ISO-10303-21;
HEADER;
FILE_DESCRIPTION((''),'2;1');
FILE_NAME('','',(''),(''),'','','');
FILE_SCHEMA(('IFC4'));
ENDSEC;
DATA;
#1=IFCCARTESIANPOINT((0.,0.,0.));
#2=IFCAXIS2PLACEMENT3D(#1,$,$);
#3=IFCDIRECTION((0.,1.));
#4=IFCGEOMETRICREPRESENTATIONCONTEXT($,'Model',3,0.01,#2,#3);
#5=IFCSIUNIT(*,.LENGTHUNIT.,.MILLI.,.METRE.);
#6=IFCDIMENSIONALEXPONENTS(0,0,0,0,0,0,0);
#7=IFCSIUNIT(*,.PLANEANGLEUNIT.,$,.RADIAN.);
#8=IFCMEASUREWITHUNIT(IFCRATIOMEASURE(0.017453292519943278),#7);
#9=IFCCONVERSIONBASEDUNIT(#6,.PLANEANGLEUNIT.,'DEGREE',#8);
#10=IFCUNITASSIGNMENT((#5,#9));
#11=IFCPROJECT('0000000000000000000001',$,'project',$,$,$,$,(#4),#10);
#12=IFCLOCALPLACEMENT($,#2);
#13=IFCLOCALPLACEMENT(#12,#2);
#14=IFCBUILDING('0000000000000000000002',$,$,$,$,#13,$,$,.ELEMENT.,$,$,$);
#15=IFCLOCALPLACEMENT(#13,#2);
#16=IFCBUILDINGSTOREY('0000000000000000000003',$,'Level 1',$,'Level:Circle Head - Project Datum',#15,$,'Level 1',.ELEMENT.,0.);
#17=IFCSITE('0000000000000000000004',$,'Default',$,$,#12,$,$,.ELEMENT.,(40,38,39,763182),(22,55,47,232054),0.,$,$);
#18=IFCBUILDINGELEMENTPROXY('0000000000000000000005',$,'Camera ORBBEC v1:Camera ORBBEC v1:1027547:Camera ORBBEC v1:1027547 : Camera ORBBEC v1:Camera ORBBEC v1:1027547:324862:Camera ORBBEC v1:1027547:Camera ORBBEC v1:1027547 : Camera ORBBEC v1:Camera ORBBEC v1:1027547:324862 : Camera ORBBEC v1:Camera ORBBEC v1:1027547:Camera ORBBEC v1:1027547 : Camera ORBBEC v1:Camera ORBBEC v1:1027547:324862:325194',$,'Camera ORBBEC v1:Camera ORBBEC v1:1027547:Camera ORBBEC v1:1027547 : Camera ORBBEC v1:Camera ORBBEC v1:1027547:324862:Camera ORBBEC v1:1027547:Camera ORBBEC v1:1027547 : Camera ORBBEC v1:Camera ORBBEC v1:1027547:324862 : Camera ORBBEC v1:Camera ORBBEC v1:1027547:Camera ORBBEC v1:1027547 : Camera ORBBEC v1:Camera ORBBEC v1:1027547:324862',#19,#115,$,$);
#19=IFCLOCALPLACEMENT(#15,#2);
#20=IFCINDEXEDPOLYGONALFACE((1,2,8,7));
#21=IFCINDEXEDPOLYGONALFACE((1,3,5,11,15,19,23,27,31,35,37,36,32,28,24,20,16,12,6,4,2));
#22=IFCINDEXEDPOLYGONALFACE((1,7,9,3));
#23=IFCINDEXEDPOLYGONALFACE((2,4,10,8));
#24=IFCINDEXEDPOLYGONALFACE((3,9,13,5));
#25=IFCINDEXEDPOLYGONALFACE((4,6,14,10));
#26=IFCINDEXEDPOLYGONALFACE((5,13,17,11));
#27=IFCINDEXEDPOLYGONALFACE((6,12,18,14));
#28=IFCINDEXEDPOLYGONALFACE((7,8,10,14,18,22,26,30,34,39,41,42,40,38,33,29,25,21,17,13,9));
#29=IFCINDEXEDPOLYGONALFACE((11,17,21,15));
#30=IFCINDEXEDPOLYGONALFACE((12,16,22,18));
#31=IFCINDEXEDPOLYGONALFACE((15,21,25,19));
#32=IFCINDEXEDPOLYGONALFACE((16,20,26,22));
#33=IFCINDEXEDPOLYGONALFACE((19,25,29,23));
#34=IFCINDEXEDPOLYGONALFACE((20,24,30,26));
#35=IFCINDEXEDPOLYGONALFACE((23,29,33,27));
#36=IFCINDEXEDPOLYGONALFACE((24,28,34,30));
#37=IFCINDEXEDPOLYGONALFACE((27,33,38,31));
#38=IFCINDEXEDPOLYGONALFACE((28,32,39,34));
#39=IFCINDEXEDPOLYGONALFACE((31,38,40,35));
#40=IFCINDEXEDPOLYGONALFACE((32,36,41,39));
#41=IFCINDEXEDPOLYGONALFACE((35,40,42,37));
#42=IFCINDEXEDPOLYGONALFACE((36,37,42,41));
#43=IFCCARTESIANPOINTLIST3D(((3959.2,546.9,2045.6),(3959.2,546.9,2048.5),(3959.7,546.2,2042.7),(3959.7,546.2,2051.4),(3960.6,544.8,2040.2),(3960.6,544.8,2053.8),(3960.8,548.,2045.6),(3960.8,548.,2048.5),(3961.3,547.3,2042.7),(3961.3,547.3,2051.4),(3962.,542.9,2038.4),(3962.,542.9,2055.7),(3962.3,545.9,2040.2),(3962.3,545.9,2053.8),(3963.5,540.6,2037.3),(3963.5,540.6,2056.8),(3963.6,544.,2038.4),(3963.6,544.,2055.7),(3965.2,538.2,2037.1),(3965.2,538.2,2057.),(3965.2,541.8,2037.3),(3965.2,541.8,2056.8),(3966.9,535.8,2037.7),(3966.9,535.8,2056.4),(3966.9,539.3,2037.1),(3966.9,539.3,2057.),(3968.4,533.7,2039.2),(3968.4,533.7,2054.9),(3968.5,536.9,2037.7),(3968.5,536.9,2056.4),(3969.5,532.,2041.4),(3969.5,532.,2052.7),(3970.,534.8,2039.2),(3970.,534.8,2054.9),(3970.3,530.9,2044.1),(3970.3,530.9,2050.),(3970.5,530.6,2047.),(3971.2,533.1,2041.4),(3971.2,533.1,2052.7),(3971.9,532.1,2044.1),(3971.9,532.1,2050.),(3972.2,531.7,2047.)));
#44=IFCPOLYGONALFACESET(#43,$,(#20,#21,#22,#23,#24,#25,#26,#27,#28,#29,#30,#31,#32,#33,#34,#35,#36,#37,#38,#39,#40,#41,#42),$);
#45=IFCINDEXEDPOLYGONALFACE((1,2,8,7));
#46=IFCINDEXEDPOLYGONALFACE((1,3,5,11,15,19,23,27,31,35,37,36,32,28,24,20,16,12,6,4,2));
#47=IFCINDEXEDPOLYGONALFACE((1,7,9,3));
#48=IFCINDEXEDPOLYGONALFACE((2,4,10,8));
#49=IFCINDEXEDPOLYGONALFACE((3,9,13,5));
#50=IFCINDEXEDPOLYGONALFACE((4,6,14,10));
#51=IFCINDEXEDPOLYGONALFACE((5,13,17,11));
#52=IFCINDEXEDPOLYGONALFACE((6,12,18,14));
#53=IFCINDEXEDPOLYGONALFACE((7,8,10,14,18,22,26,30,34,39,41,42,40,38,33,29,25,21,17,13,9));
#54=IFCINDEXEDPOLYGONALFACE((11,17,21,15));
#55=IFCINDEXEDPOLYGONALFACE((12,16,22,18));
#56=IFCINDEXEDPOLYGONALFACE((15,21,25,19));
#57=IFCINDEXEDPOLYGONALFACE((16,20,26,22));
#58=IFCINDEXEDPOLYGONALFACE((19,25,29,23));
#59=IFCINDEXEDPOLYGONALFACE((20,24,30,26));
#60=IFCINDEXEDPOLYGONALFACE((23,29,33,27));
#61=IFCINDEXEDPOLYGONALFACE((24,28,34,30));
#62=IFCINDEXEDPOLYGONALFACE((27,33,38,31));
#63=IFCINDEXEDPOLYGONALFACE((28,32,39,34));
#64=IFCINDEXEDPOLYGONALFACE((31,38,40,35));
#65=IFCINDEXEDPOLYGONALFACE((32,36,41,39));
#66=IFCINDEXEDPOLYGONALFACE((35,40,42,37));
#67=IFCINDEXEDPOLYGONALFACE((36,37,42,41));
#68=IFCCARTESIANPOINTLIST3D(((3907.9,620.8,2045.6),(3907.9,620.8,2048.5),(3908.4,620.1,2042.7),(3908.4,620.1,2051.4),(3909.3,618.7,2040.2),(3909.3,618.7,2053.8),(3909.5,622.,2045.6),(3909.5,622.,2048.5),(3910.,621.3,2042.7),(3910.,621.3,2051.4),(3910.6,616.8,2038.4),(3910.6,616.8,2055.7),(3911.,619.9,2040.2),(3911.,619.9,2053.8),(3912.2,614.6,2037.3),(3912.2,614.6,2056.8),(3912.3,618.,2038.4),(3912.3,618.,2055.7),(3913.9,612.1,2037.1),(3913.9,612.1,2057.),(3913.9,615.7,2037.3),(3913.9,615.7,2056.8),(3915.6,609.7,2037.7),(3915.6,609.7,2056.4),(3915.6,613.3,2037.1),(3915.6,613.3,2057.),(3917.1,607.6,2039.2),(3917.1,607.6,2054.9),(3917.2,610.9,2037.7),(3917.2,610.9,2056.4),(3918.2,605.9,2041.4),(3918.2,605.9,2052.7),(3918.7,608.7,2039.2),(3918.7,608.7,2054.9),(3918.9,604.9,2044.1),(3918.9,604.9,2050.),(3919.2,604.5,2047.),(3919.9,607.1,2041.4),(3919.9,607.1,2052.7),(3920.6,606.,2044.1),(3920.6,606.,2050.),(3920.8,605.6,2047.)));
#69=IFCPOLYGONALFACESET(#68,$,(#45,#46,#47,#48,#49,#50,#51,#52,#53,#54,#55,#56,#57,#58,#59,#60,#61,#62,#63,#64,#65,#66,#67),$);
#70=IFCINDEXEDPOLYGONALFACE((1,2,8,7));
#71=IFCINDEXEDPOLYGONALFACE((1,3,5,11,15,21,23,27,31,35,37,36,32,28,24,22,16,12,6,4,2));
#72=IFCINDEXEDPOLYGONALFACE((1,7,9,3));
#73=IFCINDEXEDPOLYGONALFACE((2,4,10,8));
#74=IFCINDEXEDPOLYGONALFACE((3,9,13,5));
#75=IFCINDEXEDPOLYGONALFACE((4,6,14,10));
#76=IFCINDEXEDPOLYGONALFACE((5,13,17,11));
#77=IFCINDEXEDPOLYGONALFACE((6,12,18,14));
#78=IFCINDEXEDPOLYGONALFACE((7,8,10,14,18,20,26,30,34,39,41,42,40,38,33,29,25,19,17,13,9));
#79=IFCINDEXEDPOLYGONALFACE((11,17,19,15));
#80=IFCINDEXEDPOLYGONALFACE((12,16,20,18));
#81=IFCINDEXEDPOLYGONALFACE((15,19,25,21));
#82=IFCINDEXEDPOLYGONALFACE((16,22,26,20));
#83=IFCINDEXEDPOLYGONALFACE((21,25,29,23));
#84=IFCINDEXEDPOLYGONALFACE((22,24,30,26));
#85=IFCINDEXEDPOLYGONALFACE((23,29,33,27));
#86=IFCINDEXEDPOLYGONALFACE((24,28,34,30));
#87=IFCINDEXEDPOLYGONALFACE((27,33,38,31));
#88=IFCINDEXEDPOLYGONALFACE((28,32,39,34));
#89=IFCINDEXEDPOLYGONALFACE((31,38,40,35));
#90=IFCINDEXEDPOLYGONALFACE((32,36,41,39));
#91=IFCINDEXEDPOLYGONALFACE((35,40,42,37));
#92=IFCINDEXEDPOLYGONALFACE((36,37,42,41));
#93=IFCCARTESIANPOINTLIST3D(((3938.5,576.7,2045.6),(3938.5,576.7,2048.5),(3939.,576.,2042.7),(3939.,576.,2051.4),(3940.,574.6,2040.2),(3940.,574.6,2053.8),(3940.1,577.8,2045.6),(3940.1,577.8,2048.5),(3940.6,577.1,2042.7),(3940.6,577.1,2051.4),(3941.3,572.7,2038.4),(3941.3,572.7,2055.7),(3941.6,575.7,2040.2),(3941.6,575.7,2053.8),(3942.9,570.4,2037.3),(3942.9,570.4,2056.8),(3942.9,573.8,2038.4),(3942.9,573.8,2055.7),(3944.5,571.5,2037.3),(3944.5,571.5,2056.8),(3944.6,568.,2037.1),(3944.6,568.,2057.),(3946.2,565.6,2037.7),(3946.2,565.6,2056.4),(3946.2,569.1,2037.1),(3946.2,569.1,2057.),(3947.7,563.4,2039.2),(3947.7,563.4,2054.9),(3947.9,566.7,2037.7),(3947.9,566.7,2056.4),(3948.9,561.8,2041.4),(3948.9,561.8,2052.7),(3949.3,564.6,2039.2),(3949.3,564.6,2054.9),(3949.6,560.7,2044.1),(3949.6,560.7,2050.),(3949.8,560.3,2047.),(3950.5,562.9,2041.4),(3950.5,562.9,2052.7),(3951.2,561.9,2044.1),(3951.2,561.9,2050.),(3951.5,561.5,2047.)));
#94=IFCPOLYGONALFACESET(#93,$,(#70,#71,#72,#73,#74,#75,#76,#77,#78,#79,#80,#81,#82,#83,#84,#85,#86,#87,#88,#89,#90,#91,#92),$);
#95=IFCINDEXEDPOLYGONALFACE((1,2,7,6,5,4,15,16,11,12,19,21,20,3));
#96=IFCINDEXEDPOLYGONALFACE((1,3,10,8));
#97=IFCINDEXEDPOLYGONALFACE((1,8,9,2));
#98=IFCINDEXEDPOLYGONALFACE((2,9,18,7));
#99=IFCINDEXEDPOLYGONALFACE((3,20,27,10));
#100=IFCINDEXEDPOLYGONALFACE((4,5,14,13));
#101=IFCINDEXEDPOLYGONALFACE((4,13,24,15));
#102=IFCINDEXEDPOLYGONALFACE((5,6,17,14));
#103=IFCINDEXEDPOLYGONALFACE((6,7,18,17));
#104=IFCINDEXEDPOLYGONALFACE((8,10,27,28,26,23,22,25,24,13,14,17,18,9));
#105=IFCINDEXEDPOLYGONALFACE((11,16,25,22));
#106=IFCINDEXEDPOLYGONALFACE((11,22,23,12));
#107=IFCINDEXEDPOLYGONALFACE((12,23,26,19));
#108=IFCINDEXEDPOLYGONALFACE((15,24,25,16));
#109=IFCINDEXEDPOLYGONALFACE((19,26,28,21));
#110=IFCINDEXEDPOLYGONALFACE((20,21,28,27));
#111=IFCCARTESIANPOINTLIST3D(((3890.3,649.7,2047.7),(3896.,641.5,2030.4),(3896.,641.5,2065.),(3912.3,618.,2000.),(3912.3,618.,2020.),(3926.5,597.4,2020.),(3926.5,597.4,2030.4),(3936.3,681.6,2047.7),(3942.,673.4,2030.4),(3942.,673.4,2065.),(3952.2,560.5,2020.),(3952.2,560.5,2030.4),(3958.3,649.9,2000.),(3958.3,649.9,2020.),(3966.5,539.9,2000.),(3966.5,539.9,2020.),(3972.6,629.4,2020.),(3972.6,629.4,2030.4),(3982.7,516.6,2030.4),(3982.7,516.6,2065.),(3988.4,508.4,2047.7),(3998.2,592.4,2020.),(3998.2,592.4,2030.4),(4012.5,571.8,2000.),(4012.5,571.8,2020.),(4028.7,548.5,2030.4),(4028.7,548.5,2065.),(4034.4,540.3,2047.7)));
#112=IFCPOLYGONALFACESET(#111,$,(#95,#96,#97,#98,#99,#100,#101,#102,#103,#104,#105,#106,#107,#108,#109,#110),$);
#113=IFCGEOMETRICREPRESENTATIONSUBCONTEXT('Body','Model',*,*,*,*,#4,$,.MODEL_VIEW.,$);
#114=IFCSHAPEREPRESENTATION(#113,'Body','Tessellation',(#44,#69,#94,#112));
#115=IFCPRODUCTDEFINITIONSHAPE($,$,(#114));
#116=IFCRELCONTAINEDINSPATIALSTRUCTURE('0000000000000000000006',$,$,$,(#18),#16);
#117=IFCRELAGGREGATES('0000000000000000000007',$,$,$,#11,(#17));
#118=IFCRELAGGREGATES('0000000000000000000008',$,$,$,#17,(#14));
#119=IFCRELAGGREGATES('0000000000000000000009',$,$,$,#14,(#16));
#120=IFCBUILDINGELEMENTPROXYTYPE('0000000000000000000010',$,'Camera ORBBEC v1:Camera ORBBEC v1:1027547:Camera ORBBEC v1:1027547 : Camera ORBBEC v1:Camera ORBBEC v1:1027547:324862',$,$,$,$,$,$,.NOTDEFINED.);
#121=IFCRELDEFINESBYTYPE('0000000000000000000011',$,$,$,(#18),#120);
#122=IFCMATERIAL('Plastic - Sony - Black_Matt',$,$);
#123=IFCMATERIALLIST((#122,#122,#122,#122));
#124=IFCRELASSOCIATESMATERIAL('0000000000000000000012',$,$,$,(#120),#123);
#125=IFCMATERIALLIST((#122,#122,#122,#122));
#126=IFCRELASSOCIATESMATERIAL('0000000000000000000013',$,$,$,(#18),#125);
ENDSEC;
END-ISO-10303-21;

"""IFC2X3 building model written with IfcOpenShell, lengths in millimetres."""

from ifc_helpers import new_model, entity, si_unit, converted_unit, direction, frame, frame_2d, origin, origin_2d_with_axis, place, context, subcontext, project, spatial, polyline, circle, outline, extrude, source, transform, mapped, material, material_list, type_object, type_shapes, element, save


model = new_model("IFC2X3")

# Units and contexts
model_context = context("Model", 3, precision=0.01, world=origin(), true_north=direction((0.0, 1.0)))
body_context = subcontext(model_context, "Body", "Model", "MODEL_VIEW")
ifc_project = project(units=[si_unit("LENGTHUNIT", "METRE", prefix="MILLI"), converted_unit("PLANEANGLEUNIT", "DEGREE", entity("IfcRatioMeasure", 0.017453292519943278), si_unit("PLANEANGLEUNIT", "RADIAN"), dimensions=[0, 0, 0, 0, 0, 0, 0])], contexts=[model_context])

# Site, building, storey
site_placement = place(None, origin())
site = spatial("IfcSite", under=ifc_project, at=site_placement, Name="Default", CompositionType="ELEMENT", RefLatitude=(40, 38, 39, 763182), RefLongitude=(22, 55, 47, 232054), RefElevation=0.0)
building_placement = place(site_placement, origin())
building = spatial("IfcBuilding", under=site, at=building_placement, CompositionType="ELEMENT")
storey_placement = place(building_placement, origin())
storey = spatial("IfcBuildingStorey", under=building, at=storey_placement, Name="Level 1", ObjectType="Level:Circle Head - Project Datum", LongName="Level 1", CompositionType="ELEMENT", Elevation=0.0)

# Building element proxy
ifc_material_1 = material(Name="Plastic - Sony - Black_Matt")
ifc_material_list_1 = material_list([ifc_material_1, ifc_material_1, ifc_material_1, ifc_material_1])
ifc_material_list_2 = material_list([ifc_material_1, ifc_material_1, ifc_material_1, ifc_material_1])
building_element_proxy_type_1 = type_object("IfcBuildingElementProxyType", Name="Camera ORBBEC v1:Camera ORBBEC v1:1027547:Camera ORBBEC v1:1027547 : Camera ORBBEC v1:Camera ORBBEC v1:1027547:324862", PredefinedType="NOTDEFINED", material=ifc_material_list_2)
shared_shape_1 = source(origin(), body_context, "Body", "SweptSolid", [
    extrude(circle(Radius=10.0, at=origin_2d_with_axis()), frame((3964.8, 538.8, 2047.0), z_axis=(0.821568, 0.57011, 0.0), x_axis=(0.57011, -0.821568, 0.0)), (0.0, 0.0, 1.0), 2.0),
    extrude(circle(Radius=10.0, at=frame_2d((0.0, 0.0), x_axis=(1.0, 0.0))), frame((3913.5, 612.7, 2047.0), z_axis=(0.821568, 0.57011, 0.0), x_axis=(0.57011, -0.821568, 0.0)), (0.0, 0.0, 1.0), 2.0),
    extrude(circle(Radius=10.0, at=origin_2d_with_axis()), frame((3944.1, 568.6, 2047.0), z_axis=(0.821568, 0.57011, 0.0), x_axis=(0.57011, -0.821568, 0.0)), (0.0, 0.0, 1.0), 2.0),
    extrude(outline(polyline([(8.1, -83.0), (28.1, -83.0), (38.1, -65.7), (11.4, -19.5), (20.3, -14.3), (32.8, -35.9), (50.2, -25.9), (2.7, 56.3), (-14.7, 46.3), (-2.2, 24.7), (-11.1, 19.5), (-37.9, 65.9), (-57.9, 65.9), (-67.9, 48.6), (8.1, -83.0)])), frame((3939.4, 579.0, 2030.5), z_axis=(0.821568, 0.57011, 0.0), x_axis=(0.285055, -0.410784, -0.866025)), (0.0, 0.0, 1.0), 56.0),
])
type_shapes(building_element_proxy_type_1, [shared_shape_1])
proxy_1_placement = place(storey_placement, origin())
element("IfcBuildingElementProxy", 1, at=proxy_1_placement, inside=storey, type_object=building_element_proxy_type_1, material=ifc_material_list_1, Name="Camera ORBBEC v1:Camera ORBBEC v1:1027547:Camera ORBBEC v1:1027547 : Camera ORBBEC v1:Camera ORBBEC v1:1027547:324862:Camera ORBBEC v1:1027547:Camera ORBBEC v1:1027547 : Camera ORBBEC v1:Camera ORBBEC v1:1027547:324862 : Camera ORBBEC v1:Camera ORBBEC v1:1027547:Camera ORBBEC v1:1027547 : Camera ORBBEC v1:Camera ORBBEC v1:1027547:324862:325194", ObjectType="Camera ORBBEC v1:Camera ORBBEC v1:1027547:Camera ORBBEC v1:1027547 : Camera ORBBEC v1:Camera ORBBEC v1:1027547:324862:Camera ORBBEC v1:1027547:Camera ORBBEC v1:1027547 : Camera ORBBEC v1:Camera ORBBEC v1:1027547:324862 : Camera ORBBEC v1:Camera ORBBEC v1:1027547:Camera ORBBEC v1:1027547 : Camera ORBBEC v1:Camera ORBBEC v1:1027547:324862", context=body_context, shape_type="MappedRepresentation", body=[
    mapped(shared_shape_1, transform((0.0, 0.0, 0.0), scale=1.0)),
])

save(model, "model.ifc")
